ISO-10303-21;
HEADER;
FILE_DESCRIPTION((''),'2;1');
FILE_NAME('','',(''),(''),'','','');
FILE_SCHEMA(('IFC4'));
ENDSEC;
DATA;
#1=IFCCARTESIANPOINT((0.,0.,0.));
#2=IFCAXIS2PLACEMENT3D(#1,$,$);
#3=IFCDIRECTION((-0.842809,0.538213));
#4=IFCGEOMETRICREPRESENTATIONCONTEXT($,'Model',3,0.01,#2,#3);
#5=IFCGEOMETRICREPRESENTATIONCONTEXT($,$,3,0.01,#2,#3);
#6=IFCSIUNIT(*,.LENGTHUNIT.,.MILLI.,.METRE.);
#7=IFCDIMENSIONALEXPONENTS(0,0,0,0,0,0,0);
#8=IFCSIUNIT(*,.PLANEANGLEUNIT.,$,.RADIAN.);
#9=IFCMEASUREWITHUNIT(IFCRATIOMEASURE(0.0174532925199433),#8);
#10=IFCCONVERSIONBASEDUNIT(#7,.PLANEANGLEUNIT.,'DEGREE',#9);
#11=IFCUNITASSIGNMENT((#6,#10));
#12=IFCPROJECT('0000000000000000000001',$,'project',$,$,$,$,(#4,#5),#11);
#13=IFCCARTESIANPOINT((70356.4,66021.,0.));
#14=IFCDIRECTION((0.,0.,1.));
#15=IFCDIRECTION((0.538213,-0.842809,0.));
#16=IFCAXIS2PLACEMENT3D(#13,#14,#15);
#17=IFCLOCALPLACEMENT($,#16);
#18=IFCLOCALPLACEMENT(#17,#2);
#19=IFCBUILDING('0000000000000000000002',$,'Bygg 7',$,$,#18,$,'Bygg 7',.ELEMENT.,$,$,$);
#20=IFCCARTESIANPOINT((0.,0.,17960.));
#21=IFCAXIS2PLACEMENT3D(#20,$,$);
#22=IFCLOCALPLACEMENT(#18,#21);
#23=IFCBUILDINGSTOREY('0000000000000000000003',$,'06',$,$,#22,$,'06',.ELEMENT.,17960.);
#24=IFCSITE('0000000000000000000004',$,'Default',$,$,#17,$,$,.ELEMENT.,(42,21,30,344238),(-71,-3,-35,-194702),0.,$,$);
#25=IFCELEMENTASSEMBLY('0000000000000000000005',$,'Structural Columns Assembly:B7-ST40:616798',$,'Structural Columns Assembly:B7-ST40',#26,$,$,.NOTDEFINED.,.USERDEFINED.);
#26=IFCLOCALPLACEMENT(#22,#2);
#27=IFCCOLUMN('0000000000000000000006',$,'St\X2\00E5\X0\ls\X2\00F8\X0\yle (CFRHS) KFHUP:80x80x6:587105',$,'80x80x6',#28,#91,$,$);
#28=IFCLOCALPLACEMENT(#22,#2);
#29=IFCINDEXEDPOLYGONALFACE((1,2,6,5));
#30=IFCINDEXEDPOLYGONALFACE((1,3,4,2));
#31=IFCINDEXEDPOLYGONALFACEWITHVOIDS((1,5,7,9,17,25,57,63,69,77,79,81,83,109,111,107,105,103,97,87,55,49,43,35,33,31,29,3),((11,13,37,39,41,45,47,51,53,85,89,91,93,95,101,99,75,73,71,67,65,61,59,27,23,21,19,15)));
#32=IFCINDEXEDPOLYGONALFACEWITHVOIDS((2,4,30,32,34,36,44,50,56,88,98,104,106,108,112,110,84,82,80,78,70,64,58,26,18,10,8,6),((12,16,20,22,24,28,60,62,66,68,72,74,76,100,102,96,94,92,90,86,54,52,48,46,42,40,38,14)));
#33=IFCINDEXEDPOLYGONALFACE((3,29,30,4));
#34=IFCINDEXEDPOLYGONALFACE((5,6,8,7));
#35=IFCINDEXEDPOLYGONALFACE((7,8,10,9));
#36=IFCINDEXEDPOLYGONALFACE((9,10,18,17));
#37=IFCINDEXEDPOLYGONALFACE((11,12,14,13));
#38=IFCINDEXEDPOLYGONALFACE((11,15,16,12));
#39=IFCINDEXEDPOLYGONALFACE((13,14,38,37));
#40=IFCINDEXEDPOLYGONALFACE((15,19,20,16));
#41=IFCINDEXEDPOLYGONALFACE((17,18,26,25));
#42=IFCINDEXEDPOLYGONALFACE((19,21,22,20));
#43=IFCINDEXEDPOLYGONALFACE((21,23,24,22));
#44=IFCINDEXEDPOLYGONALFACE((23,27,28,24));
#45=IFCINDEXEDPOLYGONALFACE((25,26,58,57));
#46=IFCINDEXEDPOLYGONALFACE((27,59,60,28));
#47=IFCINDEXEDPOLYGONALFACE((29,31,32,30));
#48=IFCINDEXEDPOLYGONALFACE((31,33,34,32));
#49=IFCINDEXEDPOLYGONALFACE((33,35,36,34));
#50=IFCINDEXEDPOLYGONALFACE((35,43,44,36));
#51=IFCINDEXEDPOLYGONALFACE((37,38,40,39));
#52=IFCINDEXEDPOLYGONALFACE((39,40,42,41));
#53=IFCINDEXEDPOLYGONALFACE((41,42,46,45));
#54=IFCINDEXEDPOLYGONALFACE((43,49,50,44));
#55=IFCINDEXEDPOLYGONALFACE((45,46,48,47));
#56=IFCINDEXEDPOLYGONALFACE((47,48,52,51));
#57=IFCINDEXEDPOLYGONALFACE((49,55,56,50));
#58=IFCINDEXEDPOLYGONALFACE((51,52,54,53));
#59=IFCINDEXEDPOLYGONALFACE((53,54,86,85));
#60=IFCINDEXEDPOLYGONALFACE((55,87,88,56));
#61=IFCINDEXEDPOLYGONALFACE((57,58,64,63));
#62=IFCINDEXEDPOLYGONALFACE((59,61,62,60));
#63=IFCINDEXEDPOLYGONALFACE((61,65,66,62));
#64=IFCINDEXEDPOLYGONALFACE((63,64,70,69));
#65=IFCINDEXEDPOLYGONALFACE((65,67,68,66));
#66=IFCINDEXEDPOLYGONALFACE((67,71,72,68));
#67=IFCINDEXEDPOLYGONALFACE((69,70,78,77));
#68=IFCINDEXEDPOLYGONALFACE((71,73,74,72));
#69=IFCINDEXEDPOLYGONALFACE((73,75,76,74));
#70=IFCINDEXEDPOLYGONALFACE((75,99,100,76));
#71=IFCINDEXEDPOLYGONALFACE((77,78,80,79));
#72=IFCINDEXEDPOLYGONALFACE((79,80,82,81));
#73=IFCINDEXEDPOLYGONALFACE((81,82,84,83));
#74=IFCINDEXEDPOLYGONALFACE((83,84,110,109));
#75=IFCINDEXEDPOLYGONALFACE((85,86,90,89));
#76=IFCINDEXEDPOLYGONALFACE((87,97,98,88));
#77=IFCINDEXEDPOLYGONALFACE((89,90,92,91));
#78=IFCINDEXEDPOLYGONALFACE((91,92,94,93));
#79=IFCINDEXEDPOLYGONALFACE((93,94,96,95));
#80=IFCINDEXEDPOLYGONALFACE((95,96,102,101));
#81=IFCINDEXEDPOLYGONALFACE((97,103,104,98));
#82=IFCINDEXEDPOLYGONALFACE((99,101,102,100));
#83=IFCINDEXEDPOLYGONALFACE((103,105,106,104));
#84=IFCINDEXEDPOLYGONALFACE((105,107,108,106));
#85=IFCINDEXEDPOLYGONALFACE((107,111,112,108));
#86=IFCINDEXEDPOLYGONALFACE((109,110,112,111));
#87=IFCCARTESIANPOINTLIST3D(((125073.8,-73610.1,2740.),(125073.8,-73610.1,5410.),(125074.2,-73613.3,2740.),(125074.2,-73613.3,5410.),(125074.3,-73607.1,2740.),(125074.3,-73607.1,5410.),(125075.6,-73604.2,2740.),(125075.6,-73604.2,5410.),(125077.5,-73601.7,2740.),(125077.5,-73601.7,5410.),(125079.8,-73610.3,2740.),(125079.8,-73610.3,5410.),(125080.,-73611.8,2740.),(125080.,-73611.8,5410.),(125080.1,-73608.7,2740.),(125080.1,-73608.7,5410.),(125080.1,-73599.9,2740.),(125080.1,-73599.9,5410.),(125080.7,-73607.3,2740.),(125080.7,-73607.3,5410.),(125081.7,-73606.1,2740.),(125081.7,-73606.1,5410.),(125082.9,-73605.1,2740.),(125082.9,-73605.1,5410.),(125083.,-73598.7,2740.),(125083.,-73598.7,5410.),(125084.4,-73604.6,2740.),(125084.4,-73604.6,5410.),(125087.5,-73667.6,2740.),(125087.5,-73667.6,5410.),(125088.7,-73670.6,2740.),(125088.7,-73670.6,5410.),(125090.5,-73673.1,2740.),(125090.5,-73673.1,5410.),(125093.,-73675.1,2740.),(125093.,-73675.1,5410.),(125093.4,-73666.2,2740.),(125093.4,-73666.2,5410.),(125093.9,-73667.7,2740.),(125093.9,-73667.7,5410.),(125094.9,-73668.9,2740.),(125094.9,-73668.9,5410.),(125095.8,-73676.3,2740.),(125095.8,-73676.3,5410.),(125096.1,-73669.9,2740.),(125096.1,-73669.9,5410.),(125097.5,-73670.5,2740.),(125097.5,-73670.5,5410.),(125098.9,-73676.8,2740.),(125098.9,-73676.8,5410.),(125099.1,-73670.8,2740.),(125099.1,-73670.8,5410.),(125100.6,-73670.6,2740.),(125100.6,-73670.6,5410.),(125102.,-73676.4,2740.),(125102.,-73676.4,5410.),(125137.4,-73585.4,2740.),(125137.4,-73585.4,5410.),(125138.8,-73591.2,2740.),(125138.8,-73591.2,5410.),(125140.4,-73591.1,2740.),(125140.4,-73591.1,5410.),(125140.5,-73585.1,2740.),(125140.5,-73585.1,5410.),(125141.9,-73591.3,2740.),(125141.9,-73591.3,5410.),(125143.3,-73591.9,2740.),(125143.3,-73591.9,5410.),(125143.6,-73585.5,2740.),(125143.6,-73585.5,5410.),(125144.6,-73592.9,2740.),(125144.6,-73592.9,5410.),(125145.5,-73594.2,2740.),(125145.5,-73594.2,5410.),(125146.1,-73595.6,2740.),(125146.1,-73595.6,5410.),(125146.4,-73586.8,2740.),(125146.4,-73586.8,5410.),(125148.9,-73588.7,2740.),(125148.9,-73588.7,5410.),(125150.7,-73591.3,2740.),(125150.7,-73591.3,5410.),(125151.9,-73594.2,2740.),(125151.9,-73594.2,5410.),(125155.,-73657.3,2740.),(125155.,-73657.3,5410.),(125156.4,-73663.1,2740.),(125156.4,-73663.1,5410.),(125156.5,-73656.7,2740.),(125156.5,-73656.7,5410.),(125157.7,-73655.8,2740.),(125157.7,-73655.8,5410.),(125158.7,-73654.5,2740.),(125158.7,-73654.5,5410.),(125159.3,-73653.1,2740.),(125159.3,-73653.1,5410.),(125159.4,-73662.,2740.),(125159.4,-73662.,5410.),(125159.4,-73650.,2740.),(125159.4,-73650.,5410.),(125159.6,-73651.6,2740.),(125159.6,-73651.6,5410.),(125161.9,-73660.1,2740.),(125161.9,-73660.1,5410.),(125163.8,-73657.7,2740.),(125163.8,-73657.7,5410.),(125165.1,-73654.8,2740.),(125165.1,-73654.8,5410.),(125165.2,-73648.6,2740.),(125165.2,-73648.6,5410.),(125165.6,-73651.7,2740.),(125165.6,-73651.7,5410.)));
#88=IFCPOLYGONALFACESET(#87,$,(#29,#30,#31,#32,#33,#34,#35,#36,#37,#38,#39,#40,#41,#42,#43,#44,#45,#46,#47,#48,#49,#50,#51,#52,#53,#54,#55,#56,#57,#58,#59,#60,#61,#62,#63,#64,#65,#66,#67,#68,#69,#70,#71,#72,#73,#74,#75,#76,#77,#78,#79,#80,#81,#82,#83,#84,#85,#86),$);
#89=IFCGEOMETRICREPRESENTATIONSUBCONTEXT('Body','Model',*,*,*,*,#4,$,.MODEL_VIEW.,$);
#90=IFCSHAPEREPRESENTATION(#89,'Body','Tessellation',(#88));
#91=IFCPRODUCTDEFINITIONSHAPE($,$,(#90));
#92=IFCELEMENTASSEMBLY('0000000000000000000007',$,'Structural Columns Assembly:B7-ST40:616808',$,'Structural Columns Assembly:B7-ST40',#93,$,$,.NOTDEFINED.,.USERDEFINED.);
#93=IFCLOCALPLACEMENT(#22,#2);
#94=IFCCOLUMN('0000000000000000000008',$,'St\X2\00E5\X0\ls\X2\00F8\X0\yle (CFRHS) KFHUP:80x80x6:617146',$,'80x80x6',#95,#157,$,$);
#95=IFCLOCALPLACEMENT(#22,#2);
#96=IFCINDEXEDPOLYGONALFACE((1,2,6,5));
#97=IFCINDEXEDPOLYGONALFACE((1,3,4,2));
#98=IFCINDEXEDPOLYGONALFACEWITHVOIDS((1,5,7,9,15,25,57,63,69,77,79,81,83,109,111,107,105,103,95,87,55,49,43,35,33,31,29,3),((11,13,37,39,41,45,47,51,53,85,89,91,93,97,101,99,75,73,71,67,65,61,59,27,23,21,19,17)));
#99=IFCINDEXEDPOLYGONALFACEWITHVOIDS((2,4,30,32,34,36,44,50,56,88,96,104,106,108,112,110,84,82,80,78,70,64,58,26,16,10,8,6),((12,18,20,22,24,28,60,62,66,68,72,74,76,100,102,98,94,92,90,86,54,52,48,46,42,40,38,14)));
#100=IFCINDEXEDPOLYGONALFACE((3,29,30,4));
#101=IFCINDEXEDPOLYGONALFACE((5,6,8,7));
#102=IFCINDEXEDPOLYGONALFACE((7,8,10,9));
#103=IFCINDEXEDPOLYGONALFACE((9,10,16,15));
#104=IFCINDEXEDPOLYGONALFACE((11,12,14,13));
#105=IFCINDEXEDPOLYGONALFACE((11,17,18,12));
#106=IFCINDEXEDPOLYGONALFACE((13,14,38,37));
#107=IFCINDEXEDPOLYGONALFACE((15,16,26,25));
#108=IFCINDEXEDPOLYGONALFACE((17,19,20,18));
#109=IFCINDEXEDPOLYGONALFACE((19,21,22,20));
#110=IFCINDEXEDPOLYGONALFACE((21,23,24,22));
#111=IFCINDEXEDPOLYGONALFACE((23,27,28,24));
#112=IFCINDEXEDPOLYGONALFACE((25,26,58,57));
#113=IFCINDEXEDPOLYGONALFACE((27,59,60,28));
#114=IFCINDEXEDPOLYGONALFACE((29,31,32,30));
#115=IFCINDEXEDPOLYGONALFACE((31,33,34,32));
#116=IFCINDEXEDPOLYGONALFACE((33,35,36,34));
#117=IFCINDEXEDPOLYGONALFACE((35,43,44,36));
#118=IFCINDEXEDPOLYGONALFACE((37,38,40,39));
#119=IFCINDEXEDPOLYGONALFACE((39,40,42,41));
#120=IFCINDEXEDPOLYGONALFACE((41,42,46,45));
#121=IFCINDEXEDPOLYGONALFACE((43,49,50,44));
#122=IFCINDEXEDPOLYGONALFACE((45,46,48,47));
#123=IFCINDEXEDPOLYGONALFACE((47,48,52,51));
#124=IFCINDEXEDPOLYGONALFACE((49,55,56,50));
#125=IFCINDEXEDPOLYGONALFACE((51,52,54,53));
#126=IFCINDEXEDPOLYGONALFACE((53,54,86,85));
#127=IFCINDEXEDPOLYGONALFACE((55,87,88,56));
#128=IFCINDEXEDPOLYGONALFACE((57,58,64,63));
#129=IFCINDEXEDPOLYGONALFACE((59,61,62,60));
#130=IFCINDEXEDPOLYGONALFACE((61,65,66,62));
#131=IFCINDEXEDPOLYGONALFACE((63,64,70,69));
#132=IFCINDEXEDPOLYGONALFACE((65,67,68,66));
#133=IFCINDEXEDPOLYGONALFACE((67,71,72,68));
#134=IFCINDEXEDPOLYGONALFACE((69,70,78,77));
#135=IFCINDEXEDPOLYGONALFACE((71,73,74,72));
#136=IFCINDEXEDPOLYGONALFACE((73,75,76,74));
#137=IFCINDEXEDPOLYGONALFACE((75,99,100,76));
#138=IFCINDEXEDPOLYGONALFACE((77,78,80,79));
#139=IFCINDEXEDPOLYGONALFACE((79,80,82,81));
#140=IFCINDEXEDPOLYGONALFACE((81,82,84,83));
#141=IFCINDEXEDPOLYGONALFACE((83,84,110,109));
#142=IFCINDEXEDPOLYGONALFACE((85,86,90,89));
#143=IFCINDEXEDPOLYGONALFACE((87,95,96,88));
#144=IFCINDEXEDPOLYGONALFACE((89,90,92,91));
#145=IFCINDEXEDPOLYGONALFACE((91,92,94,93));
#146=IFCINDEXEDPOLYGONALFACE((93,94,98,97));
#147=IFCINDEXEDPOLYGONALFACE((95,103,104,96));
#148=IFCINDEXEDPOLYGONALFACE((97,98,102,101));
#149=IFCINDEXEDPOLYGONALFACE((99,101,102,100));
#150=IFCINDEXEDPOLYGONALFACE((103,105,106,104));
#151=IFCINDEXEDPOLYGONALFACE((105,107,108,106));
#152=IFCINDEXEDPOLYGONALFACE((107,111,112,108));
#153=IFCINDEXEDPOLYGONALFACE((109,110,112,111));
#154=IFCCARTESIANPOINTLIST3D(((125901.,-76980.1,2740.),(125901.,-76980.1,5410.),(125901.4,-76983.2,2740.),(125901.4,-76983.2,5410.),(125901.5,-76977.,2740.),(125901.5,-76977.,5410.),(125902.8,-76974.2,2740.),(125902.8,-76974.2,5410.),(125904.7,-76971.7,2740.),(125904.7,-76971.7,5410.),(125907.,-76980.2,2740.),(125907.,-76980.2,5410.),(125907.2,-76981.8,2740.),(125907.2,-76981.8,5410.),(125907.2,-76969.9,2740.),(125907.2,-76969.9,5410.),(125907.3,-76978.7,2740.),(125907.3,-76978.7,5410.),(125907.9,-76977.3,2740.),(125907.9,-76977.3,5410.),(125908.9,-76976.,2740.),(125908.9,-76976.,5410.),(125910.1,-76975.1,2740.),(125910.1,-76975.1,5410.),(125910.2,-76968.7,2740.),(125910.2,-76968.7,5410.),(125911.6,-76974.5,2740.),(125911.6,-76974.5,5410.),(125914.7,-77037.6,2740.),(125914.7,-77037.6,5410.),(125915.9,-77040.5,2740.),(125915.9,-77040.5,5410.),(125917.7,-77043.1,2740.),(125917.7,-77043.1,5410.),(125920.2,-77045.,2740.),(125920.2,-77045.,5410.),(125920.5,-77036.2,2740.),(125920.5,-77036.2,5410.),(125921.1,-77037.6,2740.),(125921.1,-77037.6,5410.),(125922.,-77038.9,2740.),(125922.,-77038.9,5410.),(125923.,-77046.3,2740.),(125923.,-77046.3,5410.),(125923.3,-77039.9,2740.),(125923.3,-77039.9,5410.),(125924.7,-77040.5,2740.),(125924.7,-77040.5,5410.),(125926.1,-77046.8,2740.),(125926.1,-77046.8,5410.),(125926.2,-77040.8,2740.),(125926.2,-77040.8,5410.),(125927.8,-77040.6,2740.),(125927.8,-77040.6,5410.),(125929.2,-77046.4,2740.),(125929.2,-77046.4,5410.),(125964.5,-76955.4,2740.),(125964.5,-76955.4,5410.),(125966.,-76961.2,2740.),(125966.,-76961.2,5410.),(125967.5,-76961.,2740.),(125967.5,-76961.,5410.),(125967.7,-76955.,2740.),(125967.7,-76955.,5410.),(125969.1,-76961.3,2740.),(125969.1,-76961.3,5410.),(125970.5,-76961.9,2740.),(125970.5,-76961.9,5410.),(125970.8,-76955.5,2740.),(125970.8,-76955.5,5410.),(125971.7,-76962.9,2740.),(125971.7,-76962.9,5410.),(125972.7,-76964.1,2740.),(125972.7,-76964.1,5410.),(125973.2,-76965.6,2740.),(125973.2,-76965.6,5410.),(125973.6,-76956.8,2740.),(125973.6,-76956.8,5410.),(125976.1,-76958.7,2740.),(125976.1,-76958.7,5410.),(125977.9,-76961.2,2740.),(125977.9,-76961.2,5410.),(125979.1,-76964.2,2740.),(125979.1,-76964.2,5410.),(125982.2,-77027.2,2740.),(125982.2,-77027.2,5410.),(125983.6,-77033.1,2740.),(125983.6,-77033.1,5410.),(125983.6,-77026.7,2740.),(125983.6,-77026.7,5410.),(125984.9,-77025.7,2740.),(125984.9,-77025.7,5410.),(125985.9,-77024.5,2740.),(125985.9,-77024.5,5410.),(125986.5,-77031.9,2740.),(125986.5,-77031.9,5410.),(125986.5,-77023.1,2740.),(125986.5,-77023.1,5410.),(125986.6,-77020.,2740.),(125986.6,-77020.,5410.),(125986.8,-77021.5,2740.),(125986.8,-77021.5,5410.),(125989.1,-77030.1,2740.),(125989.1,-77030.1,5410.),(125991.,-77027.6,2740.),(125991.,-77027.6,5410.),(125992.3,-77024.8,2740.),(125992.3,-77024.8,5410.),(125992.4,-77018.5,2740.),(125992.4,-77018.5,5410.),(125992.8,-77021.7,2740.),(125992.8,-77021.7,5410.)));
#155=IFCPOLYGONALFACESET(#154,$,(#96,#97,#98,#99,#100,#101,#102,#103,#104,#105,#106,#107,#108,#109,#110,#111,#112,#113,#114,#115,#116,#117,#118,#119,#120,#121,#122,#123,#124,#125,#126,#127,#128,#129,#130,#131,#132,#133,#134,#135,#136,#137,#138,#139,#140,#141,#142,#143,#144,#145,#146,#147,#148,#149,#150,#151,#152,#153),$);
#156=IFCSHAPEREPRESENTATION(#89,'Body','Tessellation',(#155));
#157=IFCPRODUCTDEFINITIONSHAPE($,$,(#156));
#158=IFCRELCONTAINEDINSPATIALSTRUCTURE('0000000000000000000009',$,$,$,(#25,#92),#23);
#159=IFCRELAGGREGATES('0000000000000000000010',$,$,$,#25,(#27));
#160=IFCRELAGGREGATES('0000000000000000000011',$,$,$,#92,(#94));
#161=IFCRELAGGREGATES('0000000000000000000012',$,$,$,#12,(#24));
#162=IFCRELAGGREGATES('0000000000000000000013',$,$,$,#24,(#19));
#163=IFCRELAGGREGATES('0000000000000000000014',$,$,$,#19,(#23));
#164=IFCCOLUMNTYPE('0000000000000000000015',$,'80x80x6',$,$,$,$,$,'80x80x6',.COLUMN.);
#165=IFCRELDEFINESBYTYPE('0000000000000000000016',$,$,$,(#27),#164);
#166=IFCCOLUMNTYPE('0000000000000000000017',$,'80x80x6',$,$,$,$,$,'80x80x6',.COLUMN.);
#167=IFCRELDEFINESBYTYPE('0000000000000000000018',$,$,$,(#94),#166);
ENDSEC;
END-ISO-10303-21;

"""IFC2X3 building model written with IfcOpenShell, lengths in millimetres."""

from ifc_helpers import new_model, entity, si_unit, converted_unit, direction, frame, frame_2d, origin, place, context, subcontext, project, spatial, polyline, circle_curve, parameter, trimmed, segment, composite_curve, outline, extrude, source, transform, mapped, type_object, type_shapes, element, aggregate, save


model = new_model("IFC2X3")

# Units and contexts
model_context = context("Model", 3, precision=0.01, world=origin(), true_north=direction((-0.842809, 0.538213)))
context_of_model = context(None, 3, precision=0.01, world=origin(), true_north=direction((-0.842809, 0.538213)))
body_context = subcontext(model_context, "Body", "Model", "MODEL_VIEW")
ifc_project = project(units=[si_unit("LENGTHUNIT", "METRE", prefix="MILLI"), converted_unit("PLANEANGLEUNIT", "DEGREE", entity("IfcRatioMeasure", 0.0174532925199433), si_unit("PLANEANGLEUNIT", "RADIAN"), dimensions=[0, 0, 0, 0, 0, 0, 0])], contexts=[model_context, context_of_model])

# Site, building, storey
site_placement = place(None, frame((70356.4, 66021.0, 0.0), z_axis=(0.0, 0.0, 1.0), x_axis=(0.538213, -0.842809, 0.0)))
site = spatial("IfcSite", under=ifc_project, at=site_placement, Name="Default", CompositionType="ELEMENT", RefLatitude=(42, 21, 30, 344238), RefLongitude=(-71, -3, -35, -194702), RefElevation=0.0)
building_placement = place(site_placement, origin())
building = spatial("IfcBuilding", under=site, at=building_placement, Name="Bygg 7", LongName="Bygg 7", CompositionType="ELEMENT")
storey_placement = place(building_placement, frame((0.0, 0.0, 17960.0)))
storey = spatial("IfcBuildingStorey", under=building, at=storey_placement, Name="06", LongName="06", CompositionType="ELEMENT", Elevation=17960.0)

# Element assemblies, columns
assembly_1_placement = place(storey_placement, origin())
assembly_1 = element("IfcElementAssembly", 1, at=assembly_1_placement, inside=storey, Name="Structural Columns Assembly:B7-ST40:616798", ObjectType="Structural Columns Assembly:B7-ST40", AssemblyPlace="NOTDEFINED", PredefinedType="USERDEFINED")
column_type_1 = type_object("IfcColumnType", Name="80x80x6", ElementType="80x80x6", PredefinedType="COLUMN")
shared_shape_1 = source(origin(), body_context, "Body", "SweptSolid", [
    extrude(outline(composite_curve([segment(trimmed(circle_curve(frame_2d((-28.0, 28.0), x_axis=(1.0, 0.0)), 12.0), [parameter(90.0)], [parameter(180.0)], True, "PARAMETER"), True, "CONTINUOUS"), segment(polyline([(-40.0, 28.0), (-40.0, -28.0)]), True, "CONTINUOUS"), segment(trimmed(circle_curve(frame_2d((-28.0, -28.0), x_axis=(1.0, 0.0)), 12.0), [parameter(180.0)], [parameter(270.0)], True, "PARAMETER"), True, "CONTINUOUS"), segment(polyline([(-28.0, -40.0), (28.0, -40.0)]), True, "CONTINUOUS"), segment(trimmed(circle_curve(frame_2d((28.0, -28.0), x_axis=(1.0, 0.0)), 12.0), [parameter(270.0)], [parameter(0.0)], True, "PARAMETER"), True, "CONTINUOUS"), segment(polyline([(40.0, -28.0), (40.0, 28.0)]), True, "CONTINUOUS"), segment(trimmed(circle_curve(frame_2d((28.0, 28.0), x_axis=(1.0, 0.0)), 12.0), [parameter(0.0)], [parameter(90.0)], True, "PARAMETER"), True, "CONTINUOUS"), segment(polyline([(28.0, 40.0), (-28.0, 40.0)]), True, "CONTINUOUS")], self_intersect=False), holes=[composite_curve([segment(polyline([(-28.0, 34.0), (28.0, 34.0)]), True, "CONTINUOUS"), segment(trimmed(circle_curve(frame_2d((28.0, 28.0), x_axis=(1.0, 0.0)), 6.0), [parameter(360.0)], [parameter(90.0)], True, "PARAMETER"), False, "CONTINUOUS"), segment(polyline([(34.0, 28.0), (34.0, -28.0)]), True, "CONTINUOUS"), segment(trimmed(circle_curve(frame_2d((28.0, -28.0), x_axis=(1.0, 0.0)), 6.0), [parameter(270.0)], [parameter(360.0)], True, "PARAMETER"), False, "CONTINUOUS"), segment(polyline([(28.0, -34.0), (-28.0, -34.0)]), True, "CONTINUOUS"), segment(trimmed(circle_curve(frame_2d((-28.0, -28.0), x_axis=(1.0, 0.0)), 6.0), [parameter(180.0)], [parameter(270.0)], True, "PARAMETER"), False, "CONTINUOUS"), segment(polyline([(-34.0, -28.0), (-34.0, 28.0)]), True, "CONTINUOUS"), segment(trimmed(circle_curve(frame_2d((-28.0, 28.0), x_axis=(1.0, 0.0)), 6.0), [parameter(90.0)], [parameter(180.0)], True, "PARAMETER"), False, "CONTINUOUS")], self_intersect=False)]), frame((47.5, 47.5, 0.0), z_axis=(0.0, 0.0, 1.0), x_axis=(-0.971172, -0.238381, 0.0)), (0.0, 0.0, 1.0), 2670.0),
])
type_shapes(column_type_1, [shared_shape_1])
column_1_placement = place(assembly_1_placement, frame((125072.2, -73678.4, 2740.0)))
column_1 = element("IfcColumn", 2, at=column_1_placement, type_object=column_type_1, Name="Stålsøyle (CFRHS) KFHUP:80x80x6:587105", ObjectType="80x80x6", context=body_context, shape_type="MappedRepresentation", body=[
    mapped(shared_shape_1, transform((0.0, 0.0, 0.0), scale=1.0)),
])
assembly_2_placement = place(storey_placement, origin())
assembly_2 = element("IfcElementAssembly", 3, at=assembly_2_placement, inside=storey, Name="Structural Columns Assembly:B7-ST40:616808", ObjectType="Structural Columns Assembly:B7-ST40", AssemblyPlace="NOTDEFINED", PredefinedType="USERDEFINED")
column_type_2 = type_object("IfcColumnType", Name="80x80x6", ElementType="80x80x6", PredefinedType="COLUMN")
shared_shape_2 = source(origin(), body_context, "Body", "SweptSolid", [
    extrude(outline(composite_curve([segment(trimmed(circle_curve(frame_2d((-28.0, 28.0), x_axis=(1.0, 0.0)), 12.0), [parameter(90.0)], [parameter(180.0)], True, "PARAMETER"), True, "CONTINUOUS"), segment(polyline([(-40.0, 28.0), (-40.0, -28.0)]), True, "CONTINUOUS"), segment(trimmed(circle_curve(frame_2d((-28.0, -28.0), x_axis=(1.0, 0.0)), 12.0), [parameter(180.0)], [parameter(270.0)], True, "PARAMETER"), True, "CONTINUOUS"), segment(polyline([(-28.0, -40.0), (28.0, -40.0)]), True, "CONTINUOUS"), segment(trimmed(circle_curve(frame_2d((28.0, -28.0), x_axis=(1.0, 0.0)), 12.0), [parameter(270.0)], [parameter(0.0)], True, "PARAMETER"), True, "CONTINUOUS"), segment(polyline([(40.0, -28.0), (40.0, 28.0)]), True, "CONTINUOUS"), segment(trimmed(circle_curve(frame_2d((28.0, 28.0), x_axis=(1.0, 0.0)), 12.0), [parameter(0.0)], [parameter(90.0)], True, "PARAMETER"), True, "CONTINUOUS"), segment(polyline([(28.0, 40.0), (-28.0, 40.0)]), True, "CONTINUOUS")], self_intersect=False), holes=[composite_curve([segment(polyline([(-28.0, 34.0), (28.0, 34.0)]), True, "CONTINUOUS"), segment(trimmed(circle_curve(frame_2d((28.0, 28.0), x_axis=(1.0, 0.0)), 6.0), [parameter(360.0)], [parameter(90.0)], True, "PARAMETER"), False, "CONTINUOUS"), segment(polyline([(34.0, 28.0), (34.0, -28.0)]), True, "CONTINUOUS"), segment(trimmed(circle_curve(frame_2d((28.0, -28.0), x_axis=(1.0, 0.0)), 6.0), [parameter(270.0)], [parameter(360.0)], True, "PARAMETER"), False, "CONTINUOUS"), segment(polyline([(28.0, -34.0), (-28.0, -34.0)]), True, "CONTINUOUS"), segment(trimmed(circle_curve(frame_2d((-28.0, -28.0), x_axis=(1.0, 0.0)), 6.0), [parameter(180.0)], [parameter(270.0)], True, "PARAMETER"), False, "CONTINUOUS"), segment(polyline([(-34.0, -28.0), (-34.0, 28.0)]), True, "CONTINUOUS"), segment(trimmed(circle_curve(frame_2d((-28.0, 28.0), x_axis=(1.0, 0.0)), 6.0), [parameter(90.0)], [parameter(180.0)], True, "PARAMETER"), False, "CONTINUOUS")], self_intersect=False)]), frame((47.5, 47.5, 0.0), z_axis=(0.0, 0.0, 1.0), x_axis=(-0.971172, -0.238381, 0.0)), (0.0, 0.0, 1.0), 2670.0),
])
type_shapes(column_type_2, [shared_shape_2])
column_2_placement = place(assembly_2_placement, frame((125899.4, -77048.3, 2740.0)))
column_2 = element("IfcColumn", 4, at=column_2_placement, type_object=column_type_2, Name="Stålsøyle (CFRHS) KFHUP:80x80x6:617146", ObjectType="80x80x6", context=body_context, shape_type="MappedRepresentation", body=[
    mapped(shared_shape_2, transform((0.0, 0.0, 0.0), scale=1.0)),
])

aggregate(assembly_1, [column_1])
aggregate(assembly_2, [column_2])

save(model, "model.ifc")
